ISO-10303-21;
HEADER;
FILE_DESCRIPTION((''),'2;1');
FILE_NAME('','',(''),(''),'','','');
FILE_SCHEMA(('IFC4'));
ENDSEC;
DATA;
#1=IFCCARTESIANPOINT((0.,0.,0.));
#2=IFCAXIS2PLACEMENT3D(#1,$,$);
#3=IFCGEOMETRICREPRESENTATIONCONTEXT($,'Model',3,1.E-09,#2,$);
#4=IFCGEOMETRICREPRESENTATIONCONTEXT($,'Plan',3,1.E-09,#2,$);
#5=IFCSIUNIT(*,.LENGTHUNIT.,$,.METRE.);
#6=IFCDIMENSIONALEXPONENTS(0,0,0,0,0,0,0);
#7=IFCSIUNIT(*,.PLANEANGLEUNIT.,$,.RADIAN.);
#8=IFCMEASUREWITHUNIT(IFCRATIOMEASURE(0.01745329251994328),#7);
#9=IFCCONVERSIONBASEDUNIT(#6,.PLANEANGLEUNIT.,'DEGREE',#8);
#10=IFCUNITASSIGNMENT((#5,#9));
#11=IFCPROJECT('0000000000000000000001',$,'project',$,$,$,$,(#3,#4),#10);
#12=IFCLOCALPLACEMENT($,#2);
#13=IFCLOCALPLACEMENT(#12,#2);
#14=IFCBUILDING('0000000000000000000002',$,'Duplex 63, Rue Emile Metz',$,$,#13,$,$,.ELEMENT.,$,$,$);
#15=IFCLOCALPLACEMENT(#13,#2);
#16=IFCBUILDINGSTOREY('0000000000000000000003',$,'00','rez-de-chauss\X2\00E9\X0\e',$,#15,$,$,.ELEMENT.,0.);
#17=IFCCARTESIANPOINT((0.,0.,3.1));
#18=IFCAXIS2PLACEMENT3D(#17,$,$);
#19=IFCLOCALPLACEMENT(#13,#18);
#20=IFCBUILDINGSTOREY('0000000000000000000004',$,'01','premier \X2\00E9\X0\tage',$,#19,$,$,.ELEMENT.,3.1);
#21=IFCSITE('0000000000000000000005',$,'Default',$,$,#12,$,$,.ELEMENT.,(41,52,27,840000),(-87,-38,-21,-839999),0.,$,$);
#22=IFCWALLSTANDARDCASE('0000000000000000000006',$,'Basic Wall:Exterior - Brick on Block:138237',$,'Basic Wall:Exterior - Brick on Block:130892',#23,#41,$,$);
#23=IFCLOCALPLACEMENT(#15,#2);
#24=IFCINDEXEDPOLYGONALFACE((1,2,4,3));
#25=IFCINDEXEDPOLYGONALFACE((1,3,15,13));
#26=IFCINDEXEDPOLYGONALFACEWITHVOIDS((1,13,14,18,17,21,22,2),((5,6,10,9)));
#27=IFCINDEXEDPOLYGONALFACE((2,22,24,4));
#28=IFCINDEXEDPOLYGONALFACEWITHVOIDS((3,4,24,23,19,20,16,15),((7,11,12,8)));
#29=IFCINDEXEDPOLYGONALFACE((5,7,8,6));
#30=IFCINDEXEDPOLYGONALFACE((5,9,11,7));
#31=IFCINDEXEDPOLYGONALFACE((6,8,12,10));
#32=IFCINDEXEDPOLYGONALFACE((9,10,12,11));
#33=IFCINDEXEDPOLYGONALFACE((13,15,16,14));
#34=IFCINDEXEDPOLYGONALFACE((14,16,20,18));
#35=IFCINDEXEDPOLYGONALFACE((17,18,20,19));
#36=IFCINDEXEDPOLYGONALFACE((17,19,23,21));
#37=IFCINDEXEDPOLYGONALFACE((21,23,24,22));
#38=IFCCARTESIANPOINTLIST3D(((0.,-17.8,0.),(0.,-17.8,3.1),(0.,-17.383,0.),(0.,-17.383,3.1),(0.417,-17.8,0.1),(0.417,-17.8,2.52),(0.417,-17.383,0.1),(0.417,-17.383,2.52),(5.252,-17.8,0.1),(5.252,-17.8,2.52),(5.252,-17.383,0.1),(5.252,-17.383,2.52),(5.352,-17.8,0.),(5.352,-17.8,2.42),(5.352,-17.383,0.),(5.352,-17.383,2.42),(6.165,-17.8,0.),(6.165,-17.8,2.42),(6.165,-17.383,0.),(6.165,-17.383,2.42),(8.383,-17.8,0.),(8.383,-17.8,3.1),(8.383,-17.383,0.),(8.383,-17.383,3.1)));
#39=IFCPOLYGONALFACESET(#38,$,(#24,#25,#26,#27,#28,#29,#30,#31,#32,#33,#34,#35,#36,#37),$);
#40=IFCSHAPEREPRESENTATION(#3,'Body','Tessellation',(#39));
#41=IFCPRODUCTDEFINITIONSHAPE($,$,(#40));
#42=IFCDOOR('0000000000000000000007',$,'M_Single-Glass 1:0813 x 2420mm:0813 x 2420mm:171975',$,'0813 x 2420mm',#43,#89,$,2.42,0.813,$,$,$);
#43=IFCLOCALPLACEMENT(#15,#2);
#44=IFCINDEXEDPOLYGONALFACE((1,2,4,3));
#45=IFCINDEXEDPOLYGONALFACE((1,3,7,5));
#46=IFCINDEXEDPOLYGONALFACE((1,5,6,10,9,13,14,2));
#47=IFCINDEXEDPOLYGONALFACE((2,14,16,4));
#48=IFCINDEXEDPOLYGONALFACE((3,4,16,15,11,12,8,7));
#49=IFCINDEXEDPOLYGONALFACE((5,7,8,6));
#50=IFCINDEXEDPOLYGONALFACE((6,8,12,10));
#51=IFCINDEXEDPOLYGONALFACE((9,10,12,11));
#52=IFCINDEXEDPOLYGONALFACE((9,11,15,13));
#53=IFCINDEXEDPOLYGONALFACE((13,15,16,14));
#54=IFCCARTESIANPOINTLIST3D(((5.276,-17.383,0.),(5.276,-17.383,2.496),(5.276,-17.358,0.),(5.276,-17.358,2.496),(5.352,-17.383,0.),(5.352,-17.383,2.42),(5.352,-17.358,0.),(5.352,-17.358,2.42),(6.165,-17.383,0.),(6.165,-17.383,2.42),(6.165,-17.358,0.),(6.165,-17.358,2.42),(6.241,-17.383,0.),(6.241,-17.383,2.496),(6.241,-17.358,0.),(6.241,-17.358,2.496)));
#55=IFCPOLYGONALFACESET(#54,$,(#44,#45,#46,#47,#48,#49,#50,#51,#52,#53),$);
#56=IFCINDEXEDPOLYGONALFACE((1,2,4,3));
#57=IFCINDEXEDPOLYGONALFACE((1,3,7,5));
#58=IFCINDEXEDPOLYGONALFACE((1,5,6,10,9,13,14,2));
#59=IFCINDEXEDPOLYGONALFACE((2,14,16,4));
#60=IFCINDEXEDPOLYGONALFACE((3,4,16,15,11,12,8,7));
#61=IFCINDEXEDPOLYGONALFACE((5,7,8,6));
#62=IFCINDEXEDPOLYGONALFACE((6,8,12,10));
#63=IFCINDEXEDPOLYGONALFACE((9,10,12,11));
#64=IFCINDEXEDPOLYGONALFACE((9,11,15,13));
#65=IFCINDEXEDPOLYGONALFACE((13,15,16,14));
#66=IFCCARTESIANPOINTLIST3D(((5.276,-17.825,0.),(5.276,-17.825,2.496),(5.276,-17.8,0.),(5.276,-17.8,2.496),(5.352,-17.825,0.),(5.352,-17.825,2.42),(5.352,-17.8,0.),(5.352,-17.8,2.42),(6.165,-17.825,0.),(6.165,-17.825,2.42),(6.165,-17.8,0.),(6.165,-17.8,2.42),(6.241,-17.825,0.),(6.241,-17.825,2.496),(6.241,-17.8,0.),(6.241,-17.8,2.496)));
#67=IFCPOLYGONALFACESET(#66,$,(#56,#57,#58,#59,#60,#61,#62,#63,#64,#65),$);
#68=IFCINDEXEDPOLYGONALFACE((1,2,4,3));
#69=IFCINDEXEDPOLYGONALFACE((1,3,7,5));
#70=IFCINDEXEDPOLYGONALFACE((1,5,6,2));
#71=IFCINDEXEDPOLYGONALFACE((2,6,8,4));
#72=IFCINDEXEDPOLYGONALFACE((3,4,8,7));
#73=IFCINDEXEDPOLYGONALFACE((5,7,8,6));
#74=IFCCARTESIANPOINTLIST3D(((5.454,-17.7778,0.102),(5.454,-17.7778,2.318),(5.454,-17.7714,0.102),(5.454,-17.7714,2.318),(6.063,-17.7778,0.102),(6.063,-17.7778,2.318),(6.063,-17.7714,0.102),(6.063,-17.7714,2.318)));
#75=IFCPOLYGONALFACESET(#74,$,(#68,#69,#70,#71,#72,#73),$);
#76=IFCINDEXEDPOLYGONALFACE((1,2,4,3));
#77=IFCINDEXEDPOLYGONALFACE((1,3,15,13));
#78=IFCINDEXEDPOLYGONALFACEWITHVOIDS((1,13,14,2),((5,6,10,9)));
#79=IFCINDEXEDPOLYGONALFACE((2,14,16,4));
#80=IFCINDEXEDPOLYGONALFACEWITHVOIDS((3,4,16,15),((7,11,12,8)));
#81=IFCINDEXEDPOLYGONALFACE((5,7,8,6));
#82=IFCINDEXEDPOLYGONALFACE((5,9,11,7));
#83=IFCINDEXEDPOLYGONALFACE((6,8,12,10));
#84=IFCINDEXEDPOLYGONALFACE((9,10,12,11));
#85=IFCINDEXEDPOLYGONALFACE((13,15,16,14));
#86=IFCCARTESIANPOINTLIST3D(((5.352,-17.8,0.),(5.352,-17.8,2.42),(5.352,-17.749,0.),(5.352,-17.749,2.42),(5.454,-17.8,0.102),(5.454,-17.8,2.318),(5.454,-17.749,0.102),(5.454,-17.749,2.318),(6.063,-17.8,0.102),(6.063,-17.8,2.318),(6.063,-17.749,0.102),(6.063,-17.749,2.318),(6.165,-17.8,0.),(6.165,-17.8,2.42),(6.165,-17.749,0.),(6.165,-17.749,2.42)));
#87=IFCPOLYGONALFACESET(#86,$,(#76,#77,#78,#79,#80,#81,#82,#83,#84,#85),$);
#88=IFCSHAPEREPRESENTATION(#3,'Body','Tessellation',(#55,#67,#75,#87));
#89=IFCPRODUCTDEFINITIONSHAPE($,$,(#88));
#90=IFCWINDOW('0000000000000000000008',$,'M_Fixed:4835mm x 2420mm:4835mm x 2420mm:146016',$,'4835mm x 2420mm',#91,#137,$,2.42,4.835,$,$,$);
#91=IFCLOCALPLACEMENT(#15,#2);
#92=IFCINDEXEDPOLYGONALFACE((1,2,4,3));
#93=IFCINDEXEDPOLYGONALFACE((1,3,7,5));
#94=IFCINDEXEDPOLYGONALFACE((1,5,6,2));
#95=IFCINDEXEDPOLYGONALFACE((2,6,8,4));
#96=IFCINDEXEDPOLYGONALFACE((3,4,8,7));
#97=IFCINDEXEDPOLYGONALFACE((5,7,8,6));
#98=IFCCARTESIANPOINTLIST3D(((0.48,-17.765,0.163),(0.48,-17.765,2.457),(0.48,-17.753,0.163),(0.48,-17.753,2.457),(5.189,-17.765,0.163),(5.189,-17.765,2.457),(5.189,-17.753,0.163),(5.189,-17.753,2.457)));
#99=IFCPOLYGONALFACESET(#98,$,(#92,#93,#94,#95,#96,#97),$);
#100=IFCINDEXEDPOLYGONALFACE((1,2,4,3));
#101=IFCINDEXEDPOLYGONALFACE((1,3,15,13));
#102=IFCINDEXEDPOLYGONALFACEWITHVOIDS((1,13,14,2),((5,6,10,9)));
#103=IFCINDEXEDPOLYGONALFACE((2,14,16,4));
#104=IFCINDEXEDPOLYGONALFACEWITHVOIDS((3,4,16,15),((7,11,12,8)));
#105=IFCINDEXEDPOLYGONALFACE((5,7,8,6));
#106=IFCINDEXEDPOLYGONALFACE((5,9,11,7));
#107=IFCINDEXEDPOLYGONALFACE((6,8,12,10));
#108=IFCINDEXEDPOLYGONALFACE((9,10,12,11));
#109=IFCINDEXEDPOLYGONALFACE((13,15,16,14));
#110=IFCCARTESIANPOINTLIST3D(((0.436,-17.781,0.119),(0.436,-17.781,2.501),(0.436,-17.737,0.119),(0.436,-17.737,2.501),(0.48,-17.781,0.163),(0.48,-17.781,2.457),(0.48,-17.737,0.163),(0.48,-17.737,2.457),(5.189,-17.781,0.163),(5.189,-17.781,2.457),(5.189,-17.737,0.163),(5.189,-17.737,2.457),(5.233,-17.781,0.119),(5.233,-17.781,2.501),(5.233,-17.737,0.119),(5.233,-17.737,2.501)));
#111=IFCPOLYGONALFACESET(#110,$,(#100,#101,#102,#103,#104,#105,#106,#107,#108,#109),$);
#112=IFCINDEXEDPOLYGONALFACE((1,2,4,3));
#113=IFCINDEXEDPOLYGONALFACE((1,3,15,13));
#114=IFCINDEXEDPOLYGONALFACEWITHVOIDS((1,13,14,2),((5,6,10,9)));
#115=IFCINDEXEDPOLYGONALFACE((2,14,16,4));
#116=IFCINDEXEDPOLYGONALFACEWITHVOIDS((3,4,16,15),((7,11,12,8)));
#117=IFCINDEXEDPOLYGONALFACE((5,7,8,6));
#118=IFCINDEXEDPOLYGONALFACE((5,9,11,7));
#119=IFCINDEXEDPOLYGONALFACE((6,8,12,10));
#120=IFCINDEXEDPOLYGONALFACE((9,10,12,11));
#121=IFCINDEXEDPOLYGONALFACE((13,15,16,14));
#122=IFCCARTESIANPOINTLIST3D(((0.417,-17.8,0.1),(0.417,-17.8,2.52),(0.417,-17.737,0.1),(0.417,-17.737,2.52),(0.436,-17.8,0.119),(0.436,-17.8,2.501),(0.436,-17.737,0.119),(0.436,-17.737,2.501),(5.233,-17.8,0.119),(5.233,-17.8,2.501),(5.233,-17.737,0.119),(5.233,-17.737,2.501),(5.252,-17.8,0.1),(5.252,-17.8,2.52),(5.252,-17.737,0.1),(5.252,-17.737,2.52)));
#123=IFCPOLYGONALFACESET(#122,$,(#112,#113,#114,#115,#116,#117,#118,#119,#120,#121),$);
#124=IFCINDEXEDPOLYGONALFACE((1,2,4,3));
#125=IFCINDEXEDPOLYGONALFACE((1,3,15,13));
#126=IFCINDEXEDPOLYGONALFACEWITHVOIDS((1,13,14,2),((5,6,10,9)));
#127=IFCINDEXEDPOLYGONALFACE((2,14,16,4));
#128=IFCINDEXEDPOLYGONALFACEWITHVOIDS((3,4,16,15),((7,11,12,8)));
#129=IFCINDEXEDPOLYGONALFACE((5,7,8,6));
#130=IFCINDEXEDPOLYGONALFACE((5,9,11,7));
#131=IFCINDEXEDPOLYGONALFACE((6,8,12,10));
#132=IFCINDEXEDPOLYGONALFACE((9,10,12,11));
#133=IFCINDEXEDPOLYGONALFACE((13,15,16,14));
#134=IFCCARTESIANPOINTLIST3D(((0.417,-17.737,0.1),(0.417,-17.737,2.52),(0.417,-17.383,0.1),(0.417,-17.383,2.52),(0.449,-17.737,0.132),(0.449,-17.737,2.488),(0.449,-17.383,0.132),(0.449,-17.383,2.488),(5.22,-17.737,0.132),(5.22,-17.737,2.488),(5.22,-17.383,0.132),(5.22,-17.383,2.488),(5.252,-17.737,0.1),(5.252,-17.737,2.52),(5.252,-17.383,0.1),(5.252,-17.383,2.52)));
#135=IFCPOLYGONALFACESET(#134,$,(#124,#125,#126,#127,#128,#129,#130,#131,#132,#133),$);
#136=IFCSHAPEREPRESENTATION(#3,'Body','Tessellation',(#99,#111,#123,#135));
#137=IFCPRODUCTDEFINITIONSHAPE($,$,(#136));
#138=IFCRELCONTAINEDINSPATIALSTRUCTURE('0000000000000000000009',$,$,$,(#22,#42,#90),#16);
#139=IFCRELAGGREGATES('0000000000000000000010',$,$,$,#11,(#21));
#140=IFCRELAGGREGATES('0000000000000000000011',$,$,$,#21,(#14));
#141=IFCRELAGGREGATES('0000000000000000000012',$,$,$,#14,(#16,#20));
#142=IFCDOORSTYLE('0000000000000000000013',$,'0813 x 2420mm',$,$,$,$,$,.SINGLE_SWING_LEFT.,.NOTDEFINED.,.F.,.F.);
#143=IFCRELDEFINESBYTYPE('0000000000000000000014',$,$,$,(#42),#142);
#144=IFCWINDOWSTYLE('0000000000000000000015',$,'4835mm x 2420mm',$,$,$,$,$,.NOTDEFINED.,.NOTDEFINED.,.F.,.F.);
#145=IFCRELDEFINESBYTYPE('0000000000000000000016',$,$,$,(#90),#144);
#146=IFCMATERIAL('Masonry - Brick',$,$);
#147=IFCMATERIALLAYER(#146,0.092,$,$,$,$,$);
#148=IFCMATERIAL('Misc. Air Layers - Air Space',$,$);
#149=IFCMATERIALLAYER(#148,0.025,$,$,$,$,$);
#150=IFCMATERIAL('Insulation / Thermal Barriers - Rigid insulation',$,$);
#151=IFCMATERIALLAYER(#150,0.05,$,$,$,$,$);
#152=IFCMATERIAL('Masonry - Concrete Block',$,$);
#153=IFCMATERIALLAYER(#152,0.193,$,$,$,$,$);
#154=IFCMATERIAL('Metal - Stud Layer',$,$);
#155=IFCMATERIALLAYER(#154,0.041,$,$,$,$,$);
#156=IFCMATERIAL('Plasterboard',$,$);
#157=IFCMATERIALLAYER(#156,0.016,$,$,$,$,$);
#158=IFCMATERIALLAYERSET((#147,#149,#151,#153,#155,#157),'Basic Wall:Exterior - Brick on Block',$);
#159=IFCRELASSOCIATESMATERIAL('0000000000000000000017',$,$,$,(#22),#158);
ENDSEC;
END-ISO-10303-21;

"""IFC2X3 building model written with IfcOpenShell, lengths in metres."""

from ifc_helpers import new_model, entity, si_unit, converted_unit, frame, frame_2d, origin, origin_2d_with_axis, place, context, project, spatial, polyline, rectangle, outline, extrude, source, transform, mapped, material, layer, layer_set, layer_usage, type_object, type_shapes, element, fill, save


model = new_model("IFC2X3")

# Units and contexts
model_context = context("Model", 3, precision=1e-09, world=origin())
plan_context = context("Plan", 3, precision=1e-09, world=origin())
ifc_project = project(units=[si_unit("LENGTHUNIT", "METRE"), converted_unit("PLANEANGLEUNIT", "DEGREE", entity("IfcRatioMeasure", 0.01745329251994328), si_unit("PLANEANGLEUNIT", "RADIAN"), dimensions=[0, 0, 0, 0, 0, 0, 0])], contexts=[model_context, plan_context])

# Site, building, storey
site_placement = place(None, origin())
site = spatial("IfcSite", under=ifc_project, at=site_placement, Name="Default", CompositionType="ELEMENT", RefLatitude=(41, 52, 27, 840000), RefLongitude=(-87, -38, -21, -839999), RefElevation=0.0)
building_placement = place(site_placement, origin())
building = spatial("IfcBuilding", under=site, at=building_placement, Name="Duplex 63, Rue Emile Metz", CompositionType="ELEMENT")
storey_1_placement = place(building_placement, origin())
storey_1 = spatial("IfcBuildingStorey", under=building, at=storey_1_placement, Name="00", Description="rez-de-chaussée", CompositionType="ELEMENT", Elevation=0.0)

# Shared definitions
ifc_material_1 = material(Name="Masonry - Brick")
ifc_layer_1 = layer(ifc_material_1, 0.092)
ifc_material_2 = material(Name="Misc. Air Layers - Air Space")
ifc_layer_2 = layer(ifc_material_2, 0.025)
ifc_material_3 = material(Name="Insulation / Thermal Barriers - Rigid insulation")
ifc_layer_3 = layer(ifc_material_3, 0.05)
ifc_material_4 = material(Name="Masonry - Concrete Block")
ifc_layer_4 = layer(ifc_material_4, 0.193)
ifc_material_5 = material(Name="Metal - Stud Layer")
ifc_layer_5 = layer(ifc_material_5, 0.041)
ifc_material_6 = material(Name="Plasterboard")
ifc_layer_6 = layer(ifc_material_6, 0.016)
ifc_layer_set_1 = layer_set([ifc_layer_1, ifc_layer_2, ifc_layer_3, ifc_layer_4, ifc_layer_5, ifc_layer_6], Name="Basic Wall:Exterior - Brick on Block")
ifc_layer_usage_1 = layer_usage(ifc_layer_set_1, "AXIS2", "NEGATIVE", 0.2085)

# Shared definitions
storey_2_placement = place(building_placement, frame((0.0, 0.0, 3.1)))
storey_2 = spatial("IfcBuildingStorey", under=building, at=storey_2_placement, Name="01", Description="premier étage", CompositionType="ELEMENT", Elevation=3.1)

# Wall, openings, door, window
wall_1_placement = place(storey_1_placement, frame((8.383, -17.5915, 0.0), z_axis=(0.0, 0.0, 1.0), x_axis=(-1.0, 0.0, 0.0)))
wall_1 = element("IfcWallStandardCase", 1, at=wall_1_placement, inside=storey_1, material=ifc_layer_usage_1, Name="Basic Wall:Exterior - Brick on Block:138237", ObjectType="Basic Wall:Exterior - Brick on Block:130892", context=model_context, shape_type="SweptSolid", body=[
    extrude(rectangle(XDim=8.383, YDim=0.417, at=frame_2d((4.1915, 0.0), x_axis=(-1.0, 0.0))), origin(), (0.0, 0.0, 1.0), 3.1),
])
opening_1_placement = place(wall_1_placement, frame((3.131, -0.2085, 0.1)))
opening_1 = element("IfcOpeningElement", 2, at=opening_1_placement, cuts=wall_1, ObjectType="Opening", context=model_context, shape_type="SweptSolid", body=[
    extrude(rectangle(XDim=2.42, YDim=4.835, at=frame_2d((1.21, 2.4175), x_axis=(1.0, 0.0))), frame((0.0, 0.0, 0.0), z_axis=(0.0, 1.0, 0.0), x_axis=(0.0, 0.0, 1.0)), (0.0, 0.0, 1.0), 0.417),
])
opening_2_placement = place(wall_1_placement, frame((2.218, -0.2085, 0.0)))
opening_2 = element("IfcOpeningElement", 3, at=opening_2_placement, cuts=wall_1, ObjectType="Opening", context=model_context, shape_type="SweptSolid", body=[
    extrude(rectangle(XDim=0.813, YDim=2.42, at=frame_2d((1.21, 0.4065), x_axis=(0.0, -1.0))), frame((0.0, 0.0, 0.0), z_axis=(0.0, 1.0, 0.0), x_axis=(0.0, 0.0, 1.0)), (0.0, 0.0, 1.0), 0.417),
])
door_style_1 = type_object("IfcDoorStyle", Name="0813 x 2420mm", ConstructionType="NOTDEFINED", OperationType="SINGLE_SWING_LEFT", ParameterTakesPrecedence=False, Sizeable=False)
shared_shape_1 = source(origin(), model_context, "Body", "SweptSolid", [
    extrude(outline(polyline([(-0.4065, -1.191), (-0.4065, 1.229), (-0.4825, 1.229), (-0.4825, -1.267), (0.4825, -1.267), (0.4825, 1.229), (0.4065, 1.229), (0.4065, -1.191), (-0.4065, -1.191)])), frame((0.4065, 0.0, 1.229), z_axis=(0.0, 1.0, 0.0), x_axis=(1.0, 0.0, 0.0)), (0.0, 0.0, -1.0), 0.025),
    extrude(outline(polyline([(-0.4065, -1.191), (-0.4065, 1.229), (-0.4825, 1.229), (-0.4825, -1.267), (0.4825, -1.267), (0.4825, 1.229), (0.4065, 1.229), (0.4065, -1.191), (-0.4065, -1.191)])), frame((0.4065, 0.442, 1.229), z_axis=(0.0, 1.0, 0.0), x_axis=(1.0, 0.0, 0.0)), (0.0, 0.0, -1.0), 0.025),
    extrude(rectangle(XDim=0.609, YDim=0.0064, at=origin_2d_with_axis()), frame((0.4065, 0.3916, 0.102)), (0.0, 0.0, 1.0), 2.216),
    extrude(outline(polyline([(-1.21, -0.4065), (1.21, -0.4065), (1.21, 0.4065), (-1.21, 0.4065), (-1.21, -0.4065)]), holes=[polyline([(-1.108, 0.3045), (1.108, 0.3045), (1.108, -0.3045), (-1.108, -0.3045), (-1.108, 0.3045)])]), frame((0.4065, 0.417, 1.21), z_axis=(0.0, -1.0, 0.0), x_axis=(0.0, 0.0, -1.0)), (0.0, 0.0, 1.0), 0.051),
])
type_shapes(door_style_1, [shared_shape_1])
door_1_placement = place(opening_2_placement, origin())
door_1 = element("IfcDoor", 4, at=door_1_placement, inside=storey_1, type_object=door_style_1, Name="M_Single-Glass 1:0813 x 2420mm:0813 x 2420mm:171975", ObjectType="0813 x 2420mm", OverallHeight=2.42, OverallWidth=0.813, context=model_context, shape_type="MappedRepresentation", body=[
    mapped(shared_shape_1, transform((0.0, 0.0, 0.0), scale=1.0)),
])
fill(opening_2, door_1)
window_style_1 = type_object("IfcWindowStyle", Name="4835mm x 2420mm", ConstructionType="NOTDEFINED", OperationType="NOTDEFINED", ParameterTakesPrecedence=False, Sizeable=False)
shared_shape_2 = source(origin(), model_context, "Body", "SweptSolid", [
    extrude(rectangle(XDim=0.012, YDim=4.709, at=origin_2d_with_axis()), frame((2.4175, 0.376, 0.063), z_axis=(0.0, 0.0, 1.0), x_axis=(0.0, -1.0, 0.0)), (0.0, 0.0, 1.0), 2.294),
    extrude(outline(polyline([(-2.3985, -1.191), (2.3985, -1.191), (2.3985, 1.191), (-2.3985, 1.191), (-2.3985, -1.191)]), holes=[polyline([(-2.3545, -1.147), (-2.3545, 1.147), (2.3545, 1.147), (2.3545, -1.147), (-2.3545, -1.147)])]), frame((2.4175, 0.354, 1.21), z_axis=(0.0, 1.0, 0.0), x_axis=(1.0, 0.0, 0.0)), (0.0, 0.0, 1.0), 0.044),
    extrude(outline(polyline([(-2.4175, -1.21), (2.4175, -1.21), (2.4175, 1.21), (-2.4175, 1.21), (-2.4175, -1.21)]), holes=[polyline([(-2.3985, -1.191), (-2.3985, 1.191), (2.3985, 1.191), (2.3985, -1.191), (-2.3985, -1.191)])]), frame((2.4175, 0.354, 1.21), z_axis=(0.0, 1.0, 0.0), x_axis=(1.0, 0.0, 0.0)), (0.0, 0.0, 1.0), 0.063),
    extrude(outline(polyline([(-2.4175, -1.21), (2.4175, -1.21), (2.4175, 1.21), (-2.4175, 1.21), (-2.4175, -1.21)]), holes=[polyline([(-2.3855, -1.178), (-2.3855, 1.178), (2.3855, 1.178), (2.3855, -1.178), (-2.3855, -1.178)])]), frame((2.4175, 0.0, 1.21), z_axis=(0.0, 1.0, 0.0), x_axis=(1.0, 0.0, 0.0)), (0.0, 0.0, 1.0), 0.354),
])
type_shapes(window_style_1, [shared_shape_2])
window_1_placement = place(opening_1_placement, origin())
window_1 = element("IfcWindow", 5, at=window_1_placement, inside=storey_1, type_object=window_style_1, Name="M_Fixed:4835mm x 2420mm:4835mm x 2420mm:146016", ObjectType="4835mm x 2420mm", OverallHeight=2.42, OverallWidth=4.835, context=model_context, shape_type="MappedRepresentation", body=[
    mapped(shared_shape_2, transform((0.0, 0.0, 0.0), scale=1.0)),
])
fill(opening_1, window_1)

save(model, "model.ifc")
